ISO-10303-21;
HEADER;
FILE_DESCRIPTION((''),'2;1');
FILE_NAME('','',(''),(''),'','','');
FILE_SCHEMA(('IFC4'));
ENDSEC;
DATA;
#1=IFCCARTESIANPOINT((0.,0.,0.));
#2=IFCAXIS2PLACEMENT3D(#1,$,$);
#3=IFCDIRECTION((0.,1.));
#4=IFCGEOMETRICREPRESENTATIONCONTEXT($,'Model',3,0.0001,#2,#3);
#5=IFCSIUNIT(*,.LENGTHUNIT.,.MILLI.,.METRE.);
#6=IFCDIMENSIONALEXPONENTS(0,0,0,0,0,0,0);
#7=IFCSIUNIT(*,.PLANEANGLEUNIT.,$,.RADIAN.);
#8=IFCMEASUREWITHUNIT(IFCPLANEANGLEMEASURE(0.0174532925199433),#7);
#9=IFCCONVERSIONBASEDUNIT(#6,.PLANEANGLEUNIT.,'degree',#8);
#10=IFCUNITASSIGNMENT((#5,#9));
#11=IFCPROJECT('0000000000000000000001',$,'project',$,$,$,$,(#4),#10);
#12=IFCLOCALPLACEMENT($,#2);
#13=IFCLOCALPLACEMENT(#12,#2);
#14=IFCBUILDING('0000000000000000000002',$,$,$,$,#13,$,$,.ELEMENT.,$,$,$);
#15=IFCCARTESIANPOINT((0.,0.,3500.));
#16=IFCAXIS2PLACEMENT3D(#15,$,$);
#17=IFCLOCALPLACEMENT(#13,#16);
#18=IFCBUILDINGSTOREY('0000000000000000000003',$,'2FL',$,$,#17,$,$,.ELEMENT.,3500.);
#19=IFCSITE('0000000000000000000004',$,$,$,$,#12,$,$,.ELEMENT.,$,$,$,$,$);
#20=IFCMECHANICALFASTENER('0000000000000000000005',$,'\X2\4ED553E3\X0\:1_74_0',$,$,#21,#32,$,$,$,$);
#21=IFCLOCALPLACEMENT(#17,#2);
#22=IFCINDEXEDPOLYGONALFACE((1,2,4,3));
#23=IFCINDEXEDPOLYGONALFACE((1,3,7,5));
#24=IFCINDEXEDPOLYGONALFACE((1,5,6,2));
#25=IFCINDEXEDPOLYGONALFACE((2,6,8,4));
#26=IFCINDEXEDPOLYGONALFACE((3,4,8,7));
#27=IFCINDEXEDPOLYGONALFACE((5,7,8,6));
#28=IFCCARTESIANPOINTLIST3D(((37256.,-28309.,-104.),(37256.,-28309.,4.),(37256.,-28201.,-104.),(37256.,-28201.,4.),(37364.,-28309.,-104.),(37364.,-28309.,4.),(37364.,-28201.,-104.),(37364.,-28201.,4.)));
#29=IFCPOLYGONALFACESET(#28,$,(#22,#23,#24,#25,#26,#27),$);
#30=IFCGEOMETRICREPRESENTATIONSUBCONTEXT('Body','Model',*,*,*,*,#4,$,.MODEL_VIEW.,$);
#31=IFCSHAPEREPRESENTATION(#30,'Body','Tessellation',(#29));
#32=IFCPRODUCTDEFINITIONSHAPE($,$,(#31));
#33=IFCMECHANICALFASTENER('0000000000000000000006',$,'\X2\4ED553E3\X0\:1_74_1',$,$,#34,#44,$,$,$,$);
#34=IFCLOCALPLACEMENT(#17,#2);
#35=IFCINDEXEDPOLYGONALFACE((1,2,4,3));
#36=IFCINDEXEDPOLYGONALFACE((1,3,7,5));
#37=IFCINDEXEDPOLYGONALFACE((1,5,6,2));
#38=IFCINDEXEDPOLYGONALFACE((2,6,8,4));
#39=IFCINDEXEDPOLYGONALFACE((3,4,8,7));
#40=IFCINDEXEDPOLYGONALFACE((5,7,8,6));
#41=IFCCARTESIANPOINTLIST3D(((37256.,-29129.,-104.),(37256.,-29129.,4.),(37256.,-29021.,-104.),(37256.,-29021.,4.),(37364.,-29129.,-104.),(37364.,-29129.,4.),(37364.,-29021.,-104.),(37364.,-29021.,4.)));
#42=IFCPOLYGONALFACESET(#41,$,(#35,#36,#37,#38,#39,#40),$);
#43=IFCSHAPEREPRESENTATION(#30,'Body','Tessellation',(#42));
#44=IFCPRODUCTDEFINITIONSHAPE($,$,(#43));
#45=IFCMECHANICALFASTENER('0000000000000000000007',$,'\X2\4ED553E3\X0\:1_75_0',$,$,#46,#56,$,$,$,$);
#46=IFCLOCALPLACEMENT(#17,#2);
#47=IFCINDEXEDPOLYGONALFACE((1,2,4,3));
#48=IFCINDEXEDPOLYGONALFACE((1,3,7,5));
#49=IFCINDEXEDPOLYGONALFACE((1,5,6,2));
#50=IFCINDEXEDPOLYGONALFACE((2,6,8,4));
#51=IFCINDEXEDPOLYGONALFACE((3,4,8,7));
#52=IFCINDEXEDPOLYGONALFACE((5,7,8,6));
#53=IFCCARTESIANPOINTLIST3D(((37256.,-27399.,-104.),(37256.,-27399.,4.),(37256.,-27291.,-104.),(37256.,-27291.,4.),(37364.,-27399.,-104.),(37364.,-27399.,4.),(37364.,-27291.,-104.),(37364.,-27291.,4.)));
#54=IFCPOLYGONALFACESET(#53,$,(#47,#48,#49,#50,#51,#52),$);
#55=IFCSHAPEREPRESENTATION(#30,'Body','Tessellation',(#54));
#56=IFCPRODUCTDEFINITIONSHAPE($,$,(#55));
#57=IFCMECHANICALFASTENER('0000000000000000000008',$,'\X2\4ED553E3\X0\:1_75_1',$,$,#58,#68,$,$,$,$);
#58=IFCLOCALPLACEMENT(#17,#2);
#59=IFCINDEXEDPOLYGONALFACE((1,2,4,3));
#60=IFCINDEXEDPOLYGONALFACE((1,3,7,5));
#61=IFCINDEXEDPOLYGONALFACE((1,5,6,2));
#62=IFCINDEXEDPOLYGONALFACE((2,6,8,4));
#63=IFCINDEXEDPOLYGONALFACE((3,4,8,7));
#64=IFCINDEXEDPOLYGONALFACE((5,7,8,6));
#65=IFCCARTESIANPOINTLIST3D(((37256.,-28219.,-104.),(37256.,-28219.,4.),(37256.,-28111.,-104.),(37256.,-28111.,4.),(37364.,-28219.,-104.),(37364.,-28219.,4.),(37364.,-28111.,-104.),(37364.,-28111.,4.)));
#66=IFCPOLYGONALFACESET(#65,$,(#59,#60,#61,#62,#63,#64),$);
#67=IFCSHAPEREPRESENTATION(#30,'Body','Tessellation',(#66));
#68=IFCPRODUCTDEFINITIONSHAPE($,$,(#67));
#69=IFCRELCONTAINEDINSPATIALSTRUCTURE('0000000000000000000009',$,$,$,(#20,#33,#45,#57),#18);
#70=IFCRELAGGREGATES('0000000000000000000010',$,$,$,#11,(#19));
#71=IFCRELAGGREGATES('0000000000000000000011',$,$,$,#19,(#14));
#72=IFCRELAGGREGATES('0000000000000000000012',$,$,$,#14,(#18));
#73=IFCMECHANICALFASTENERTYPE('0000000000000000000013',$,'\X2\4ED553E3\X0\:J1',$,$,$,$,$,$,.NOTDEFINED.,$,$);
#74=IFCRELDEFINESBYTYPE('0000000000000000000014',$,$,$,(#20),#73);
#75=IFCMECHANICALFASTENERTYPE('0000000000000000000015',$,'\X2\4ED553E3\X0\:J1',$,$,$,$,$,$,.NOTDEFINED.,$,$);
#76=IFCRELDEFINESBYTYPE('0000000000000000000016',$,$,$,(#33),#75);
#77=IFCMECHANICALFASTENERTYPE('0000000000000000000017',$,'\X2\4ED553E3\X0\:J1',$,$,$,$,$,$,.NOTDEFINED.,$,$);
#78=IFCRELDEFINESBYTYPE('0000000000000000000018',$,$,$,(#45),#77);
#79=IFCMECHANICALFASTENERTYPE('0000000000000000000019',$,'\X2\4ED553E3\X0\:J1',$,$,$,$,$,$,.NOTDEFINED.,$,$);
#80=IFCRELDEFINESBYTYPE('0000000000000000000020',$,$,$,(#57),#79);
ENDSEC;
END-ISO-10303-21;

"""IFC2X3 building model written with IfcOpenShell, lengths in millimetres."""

from ifc_helpers import new_model, entity, si_unit, converted_unit, direction, frame, origin, origin_with_axes, origin_2d, place, context, subcontext, project, spatial, rectangle, extrude, type_object, element, save


model = new_model("IFC2X3")

# Units and contexts
model_context = context("Model", 3, precision=0.0001, world=origin(), true_north=direction((0.0, 1.0)))
body_context = subcontext(model_context, "Body", "Model", "MODEL_VIEW")
ifc_project = project(units=[si_unit("LENGTHUNIT", "METRE", prefix="MILLI"), converted_unit("PLANEANGLEUNIT", "degree", entity("IfcPlaneAngleMeasure", 0.0174532925199433), si_unit("PLANEANGLEUNIT", "RADIAN"), dimensions=[0, 0, 0, 0, 0, 0, 0])], contexts=[model_context])

# Site, building, storey
site_placement = place(None, origin())
site = spatial("IfcSite", under=ifc_project, at=site_placement, CompositionType="ELEMENT")
building_placement = place(site_placement, origin())
building = spatial("IfcBuilding", under=site, at=building_placement, CompositionType="ELEMENT")
storey_placement = place(building_placement, frame((0.0, 0.0, 3500.0)))
storey = spatial("IfcBuildingStorey", under=building, at=storey_placement, Name="2FL", CompositionType="ELEMENT", Elevation=3500.0)

# Mechanical fasteners
mechanical_fastener_type_1 = type_object("IfcMechanicalFastenerType", Name="仕口:J1")
mechanical_fastener_1_placement = place(storey_placement, frame((37310.0, -28255.0, -104.0)))
element("IfcMechanicalFastener", 1, at=mechanical_fastener_1_placement, inside=storey, type_object=mechanical_fastener_type_1, Name="仕口:1_74_0", context=body_context, shape_type="SweptSolid", body=[
    extrude(rectangle(XDim=108.0, YDim=108.0, at=origin_2d()), origin_with_axes(), (0.0, 0.0, 1.0), 108.0),
])
mechanical_fastener_type_2 = type_object("IfcMechanicalFastenerType", Name="仕口:J1")
mechanical_fastener_2_placement = place(storey_placement, frame((37310.0, -29075.0, -104.0)))
element("IfcMechanicalFastener", 2, at=mechanical_fastener_2_placement, inside=storey, type_object=mechanical_fastener_type_2, Name="仕口:1_74_1", context=body_context, shape_type="SweptSolid", body=[
    extrude(rectangle(XDim=108.0, YDim=108.0, at=origin_2d()), origin_with_axes(), (0.0, 0.0, 1.0), 108.0),
])
mechanical_fastener_type_3 = type_object("IfcMechanicalFastenerType", Name="仕口:J1")
mechanical_fastener_3_placement = place(storey_placement, frame((37310.0, -27345.0, -104.0)))
element("IfcMechanicalFastener", 3, at=mechanical_fastener_3_placement, inside=storey, type_object=mechanical_fastener_type_3, Name="仕口:1_75_0", context=body_context, shape_type="SweptSolid", body=[
    extrude(rectangle(XDim=108.0, YDim=108.0, at=origin_2d()), origin_with_axes(), (0.0, 0.0, 1.0), 108.0),
])
mechanical_fastener_type_4 = type_object("IfcMechanicalFastenerType", Name="仕口:J1")
mechanical_fastener_4_placement = place(storey_placement, frame((37310.0, -28165.0, -104.0)))
element("IfcMechanicalFastener", 4, at=mechanical_fastener_4_placement, inside=storey, type_object=mechanical_fastener_type_4, Name="仕口:1_75_1", context=body_context, shape_type="SweptSolid", body=[
    extrude(rectangle(XDim=108.0, YDim=108.0, at=origin_2d()), origin_with_axes(), (0.0, 0.0, 1.0), 108.0),
])

save(model, "model.ifc")
